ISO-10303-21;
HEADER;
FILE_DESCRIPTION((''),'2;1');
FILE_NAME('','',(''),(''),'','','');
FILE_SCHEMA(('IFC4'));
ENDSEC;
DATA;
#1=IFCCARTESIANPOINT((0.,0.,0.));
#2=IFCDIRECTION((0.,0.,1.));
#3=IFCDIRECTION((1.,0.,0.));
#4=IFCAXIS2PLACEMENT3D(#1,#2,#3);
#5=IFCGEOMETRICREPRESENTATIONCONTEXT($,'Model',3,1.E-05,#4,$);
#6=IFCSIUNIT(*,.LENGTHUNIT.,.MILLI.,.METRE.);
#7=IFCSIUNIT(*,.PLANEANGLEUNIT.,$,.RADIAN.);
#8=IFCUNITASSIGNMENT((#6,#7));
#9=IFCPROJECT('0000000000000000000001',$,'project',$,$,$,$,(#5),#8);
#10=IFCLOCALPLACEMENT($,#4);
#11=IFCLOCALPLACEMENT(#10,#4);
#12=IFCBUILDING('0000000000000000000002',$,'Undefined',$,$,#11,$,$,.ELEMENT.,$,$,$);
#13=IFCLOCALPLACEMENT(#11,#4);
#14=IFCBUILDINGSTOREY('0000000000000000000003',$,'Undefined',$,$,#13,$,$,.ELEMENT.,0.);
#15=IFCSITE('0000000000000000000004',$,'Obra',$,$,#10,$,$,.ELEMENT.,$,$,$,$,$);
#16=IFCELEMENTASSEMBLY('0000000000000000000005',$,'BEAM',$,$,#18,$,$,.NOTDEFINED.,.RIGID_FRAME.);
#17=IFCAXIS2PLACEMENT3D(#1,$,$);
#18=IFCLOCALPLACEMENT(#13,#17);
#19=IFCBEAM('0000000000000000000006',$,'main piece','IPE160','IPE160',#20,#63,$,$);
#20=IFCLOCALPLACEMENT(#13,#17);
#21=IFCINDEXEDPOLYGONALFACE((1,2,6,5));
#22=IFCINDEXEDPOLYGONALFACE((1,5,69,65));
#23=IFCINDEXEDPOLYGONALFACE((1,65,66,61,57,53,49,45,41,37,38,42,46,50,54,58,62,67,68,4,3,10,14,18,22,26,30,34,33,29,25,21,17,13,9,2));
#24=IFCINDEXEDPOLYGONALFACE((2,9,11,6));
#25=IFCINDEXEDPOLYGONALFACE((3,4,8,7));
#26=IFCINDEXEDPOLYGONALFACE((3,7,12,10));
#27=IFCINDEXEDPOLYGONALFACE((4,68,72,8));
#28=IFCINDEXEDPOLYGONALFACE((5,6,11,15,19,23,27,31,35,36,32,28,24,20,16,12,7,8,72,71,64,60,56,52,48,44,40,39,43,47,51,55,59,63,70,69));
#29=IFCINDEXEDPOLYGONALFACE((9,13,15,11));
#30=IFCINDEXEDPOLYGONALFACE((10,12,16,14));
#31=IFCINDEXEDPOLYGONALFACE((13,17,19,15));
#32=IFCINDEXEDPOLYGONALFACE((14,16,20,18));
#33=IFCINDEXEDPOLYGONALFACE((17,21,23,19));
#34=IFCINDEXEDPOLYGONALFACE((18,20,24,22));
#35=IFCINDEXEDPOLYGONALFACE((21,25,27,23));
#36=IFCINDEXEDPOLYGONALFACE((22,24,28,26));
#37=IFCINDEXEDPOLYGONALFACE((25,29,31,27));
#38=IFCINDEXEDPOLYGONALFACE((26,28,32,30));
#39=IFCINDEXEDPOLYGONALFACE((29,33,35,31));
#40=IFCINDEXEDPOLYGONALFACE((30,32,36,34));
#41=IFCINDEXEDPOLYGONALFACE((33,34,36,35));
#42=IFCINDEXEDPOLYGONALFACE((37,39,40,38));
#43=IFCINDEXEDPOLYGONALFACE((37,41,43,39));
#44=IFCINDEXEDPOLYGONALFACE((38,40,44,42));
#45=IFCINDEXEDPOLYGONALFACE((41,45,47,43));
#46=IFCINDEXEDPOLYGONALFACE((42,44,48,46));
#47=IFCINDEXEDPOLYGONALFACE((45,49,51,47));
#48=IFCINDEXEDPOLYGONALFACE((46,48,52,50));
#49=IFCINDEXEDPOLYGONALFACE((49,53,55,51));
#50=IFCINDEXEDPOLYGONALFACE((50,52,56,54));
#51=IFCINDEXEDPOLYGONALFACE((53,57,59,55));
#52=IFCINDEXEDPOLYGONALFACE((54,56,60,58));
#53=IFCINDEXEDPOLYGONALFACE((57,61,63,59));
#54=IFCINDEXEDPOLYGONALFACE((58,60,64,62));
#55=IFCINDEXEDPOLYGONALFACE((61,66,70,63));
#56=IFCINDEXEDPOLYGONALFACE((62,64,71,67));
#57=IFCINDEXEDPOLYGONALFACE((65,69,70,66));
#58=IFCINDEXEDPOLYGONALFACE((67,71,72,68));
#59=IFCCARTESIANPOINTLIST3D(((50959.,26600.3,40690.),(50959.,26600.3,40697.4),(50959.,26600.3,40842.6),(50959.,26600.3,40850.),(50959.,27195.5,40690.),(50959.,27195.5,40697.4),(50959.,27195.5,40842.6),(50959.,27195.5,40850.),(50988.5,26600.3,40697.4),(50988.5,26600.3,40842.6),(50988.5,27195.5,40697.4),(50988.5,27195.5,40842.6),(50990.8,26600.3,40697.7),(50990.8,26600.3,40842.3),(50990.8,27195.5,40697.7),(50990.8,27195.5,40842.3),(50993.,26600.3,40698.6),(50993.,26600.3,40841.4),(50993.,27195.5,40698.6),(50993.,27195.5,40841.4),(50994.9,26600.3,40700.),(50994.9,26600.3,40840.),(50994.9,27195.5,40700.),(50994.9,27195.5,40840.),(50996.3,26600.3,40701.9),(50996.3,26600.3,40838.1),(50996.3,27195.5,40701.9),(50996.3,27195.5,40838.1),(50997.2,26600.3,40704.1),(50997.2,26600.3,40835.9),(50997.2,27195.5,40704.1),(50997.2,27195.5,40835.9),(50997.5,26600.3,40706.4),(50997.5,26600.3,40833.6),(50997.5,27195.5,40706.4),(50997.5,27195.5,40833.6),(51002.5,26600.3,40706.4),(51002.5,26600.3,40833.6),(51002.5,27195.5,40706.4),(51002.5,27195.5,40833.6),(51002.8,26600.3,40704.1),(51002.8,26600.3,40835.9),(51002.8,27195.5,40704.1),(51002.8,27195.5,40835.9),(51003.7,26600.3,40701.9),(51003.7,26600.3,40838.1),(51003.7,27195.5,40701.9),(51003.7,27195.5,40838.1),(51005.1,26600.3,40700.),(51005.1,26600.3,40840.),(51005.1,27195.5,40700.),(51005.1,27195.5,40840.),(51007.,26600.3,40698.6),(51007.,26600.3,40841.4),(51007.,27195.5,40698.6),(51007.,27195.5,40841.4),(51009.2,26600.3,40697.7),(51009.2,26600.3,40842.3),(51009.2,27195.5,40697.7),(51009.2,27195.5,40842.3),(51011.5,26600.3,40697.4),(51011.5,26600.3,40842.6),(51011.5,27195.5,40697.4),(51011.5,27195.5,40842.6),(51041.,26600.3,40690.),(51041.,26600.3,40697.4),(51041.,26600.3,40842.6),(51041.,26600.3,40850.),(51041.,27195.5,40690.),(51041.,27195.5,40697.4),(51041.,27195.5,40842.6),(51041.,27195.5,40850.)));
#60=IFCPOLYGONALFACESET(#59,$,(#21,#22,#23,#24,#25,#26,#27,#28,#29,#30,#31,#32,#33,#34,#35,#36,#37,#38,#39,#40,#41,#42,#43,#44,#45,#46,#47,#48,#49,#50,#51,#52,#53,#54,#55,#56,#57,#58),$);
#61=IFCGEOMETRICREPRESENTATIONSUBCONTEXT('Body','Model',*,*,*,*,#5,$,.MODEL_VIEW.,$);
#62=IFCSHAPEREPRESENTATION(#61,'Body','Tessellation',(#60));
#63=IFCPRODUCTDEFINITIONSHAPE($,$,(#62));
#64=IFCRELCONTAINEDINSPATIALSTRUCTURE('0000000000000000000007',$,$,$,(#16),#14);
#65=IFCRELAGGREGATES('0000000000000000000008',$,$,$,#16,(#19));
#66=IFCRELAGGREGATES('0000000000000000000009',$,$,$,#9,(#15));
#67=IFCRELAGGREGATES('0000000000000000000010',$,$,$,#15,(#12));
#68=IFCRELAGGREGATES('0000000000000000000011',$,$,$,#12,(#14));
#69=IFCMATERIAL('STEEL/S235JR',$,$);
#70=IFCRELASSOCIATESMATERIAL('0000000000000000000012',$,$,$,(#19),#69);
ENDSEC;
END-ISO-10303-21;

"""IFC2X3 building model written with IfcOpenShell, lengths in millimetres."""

from ifc_helpers import new_model, si_unit, frame, origin_with_axes, origin_2d_with_axis, place, context, subcontext, project, spatial, i_section, extrude, material, element, aggregate, save


model = new_model("IFC2X3")

# Units and contexts
model_context = context("Model", 3, precision=1e-05, world=origin_with_axes())
body_context = subcontext(model_context, "Body", "Model", "MODEL_VIEW")
ifc_project = project(units=[si_unit("LENGTHUNIT", "METRE", prefix="MILLI"), si_unit("PLANEANGLEUNIT", "RADIAN")], contexts=[model_context])

# Site, building, storey
site_placement = place(None, origin_with_axes())
site = spatial("IfcSite", under=ifc_project, at=site_placement, Name="Obra", CompositionType="ELEMENT")
building_placement = place(site_placement, origin_with_axes())
building = spatial("IfcBuilding", under=site, at=building_placement, Name="Undefined", CompositionType="ELEMENT")
storey_placement = place(building_placement, origin_with_axes())
storey = spatial("IfcBuildingStorey", under=building, at=storey_placement, Name="Undefined", CompositionType="ELEMENT", Elevation=0.0)

# Shared definitions
ifc_material_1 = material(Name="STEEL/S235JR")

# Element assembly, beam
assembly_1_placement = place(storey_placement, origin_with_axes())
assembly_1 = element("IfcElementAssembly", 1, at=assembly_1_placement, inside=storey, Name="BEAM", AssemblyPlace="NOTDEFINED", PredefinedType="RIGID_FRAME")
beam_1_placement = place(assembly_1_placement, frame((51000.0, 26600.3, 40770.0), z_axis=(0.0, 0.0, 1.0), x_axis=(0.0, 1.0, 0.0)))
beam_1 = element("IfcBeam", 2, at=beam_1_placement, material=ifc_material_1, Name="main piece", Description="IPE160", ObjectType="IPE160", context=body_context, shape_type="SweptSolid", body=[
    extrude(i_section(OverallWidth=82.0, OverallDepth=160.0, WebThickness=5.0, FlangeThickness=7.4, FilletRadius=9.0, at=origin_2d_with_axis()), frame((595.2, 0.0, 0.0), z_axis=(-1.0, 0.0, 0.0), x_axis=(0.0, -1.0, 0.0)), (0.0, 0.0, 1.0), 595.2),
])
aggregate(assembly_1, [beam_1])

save(model, "model.ifc")
